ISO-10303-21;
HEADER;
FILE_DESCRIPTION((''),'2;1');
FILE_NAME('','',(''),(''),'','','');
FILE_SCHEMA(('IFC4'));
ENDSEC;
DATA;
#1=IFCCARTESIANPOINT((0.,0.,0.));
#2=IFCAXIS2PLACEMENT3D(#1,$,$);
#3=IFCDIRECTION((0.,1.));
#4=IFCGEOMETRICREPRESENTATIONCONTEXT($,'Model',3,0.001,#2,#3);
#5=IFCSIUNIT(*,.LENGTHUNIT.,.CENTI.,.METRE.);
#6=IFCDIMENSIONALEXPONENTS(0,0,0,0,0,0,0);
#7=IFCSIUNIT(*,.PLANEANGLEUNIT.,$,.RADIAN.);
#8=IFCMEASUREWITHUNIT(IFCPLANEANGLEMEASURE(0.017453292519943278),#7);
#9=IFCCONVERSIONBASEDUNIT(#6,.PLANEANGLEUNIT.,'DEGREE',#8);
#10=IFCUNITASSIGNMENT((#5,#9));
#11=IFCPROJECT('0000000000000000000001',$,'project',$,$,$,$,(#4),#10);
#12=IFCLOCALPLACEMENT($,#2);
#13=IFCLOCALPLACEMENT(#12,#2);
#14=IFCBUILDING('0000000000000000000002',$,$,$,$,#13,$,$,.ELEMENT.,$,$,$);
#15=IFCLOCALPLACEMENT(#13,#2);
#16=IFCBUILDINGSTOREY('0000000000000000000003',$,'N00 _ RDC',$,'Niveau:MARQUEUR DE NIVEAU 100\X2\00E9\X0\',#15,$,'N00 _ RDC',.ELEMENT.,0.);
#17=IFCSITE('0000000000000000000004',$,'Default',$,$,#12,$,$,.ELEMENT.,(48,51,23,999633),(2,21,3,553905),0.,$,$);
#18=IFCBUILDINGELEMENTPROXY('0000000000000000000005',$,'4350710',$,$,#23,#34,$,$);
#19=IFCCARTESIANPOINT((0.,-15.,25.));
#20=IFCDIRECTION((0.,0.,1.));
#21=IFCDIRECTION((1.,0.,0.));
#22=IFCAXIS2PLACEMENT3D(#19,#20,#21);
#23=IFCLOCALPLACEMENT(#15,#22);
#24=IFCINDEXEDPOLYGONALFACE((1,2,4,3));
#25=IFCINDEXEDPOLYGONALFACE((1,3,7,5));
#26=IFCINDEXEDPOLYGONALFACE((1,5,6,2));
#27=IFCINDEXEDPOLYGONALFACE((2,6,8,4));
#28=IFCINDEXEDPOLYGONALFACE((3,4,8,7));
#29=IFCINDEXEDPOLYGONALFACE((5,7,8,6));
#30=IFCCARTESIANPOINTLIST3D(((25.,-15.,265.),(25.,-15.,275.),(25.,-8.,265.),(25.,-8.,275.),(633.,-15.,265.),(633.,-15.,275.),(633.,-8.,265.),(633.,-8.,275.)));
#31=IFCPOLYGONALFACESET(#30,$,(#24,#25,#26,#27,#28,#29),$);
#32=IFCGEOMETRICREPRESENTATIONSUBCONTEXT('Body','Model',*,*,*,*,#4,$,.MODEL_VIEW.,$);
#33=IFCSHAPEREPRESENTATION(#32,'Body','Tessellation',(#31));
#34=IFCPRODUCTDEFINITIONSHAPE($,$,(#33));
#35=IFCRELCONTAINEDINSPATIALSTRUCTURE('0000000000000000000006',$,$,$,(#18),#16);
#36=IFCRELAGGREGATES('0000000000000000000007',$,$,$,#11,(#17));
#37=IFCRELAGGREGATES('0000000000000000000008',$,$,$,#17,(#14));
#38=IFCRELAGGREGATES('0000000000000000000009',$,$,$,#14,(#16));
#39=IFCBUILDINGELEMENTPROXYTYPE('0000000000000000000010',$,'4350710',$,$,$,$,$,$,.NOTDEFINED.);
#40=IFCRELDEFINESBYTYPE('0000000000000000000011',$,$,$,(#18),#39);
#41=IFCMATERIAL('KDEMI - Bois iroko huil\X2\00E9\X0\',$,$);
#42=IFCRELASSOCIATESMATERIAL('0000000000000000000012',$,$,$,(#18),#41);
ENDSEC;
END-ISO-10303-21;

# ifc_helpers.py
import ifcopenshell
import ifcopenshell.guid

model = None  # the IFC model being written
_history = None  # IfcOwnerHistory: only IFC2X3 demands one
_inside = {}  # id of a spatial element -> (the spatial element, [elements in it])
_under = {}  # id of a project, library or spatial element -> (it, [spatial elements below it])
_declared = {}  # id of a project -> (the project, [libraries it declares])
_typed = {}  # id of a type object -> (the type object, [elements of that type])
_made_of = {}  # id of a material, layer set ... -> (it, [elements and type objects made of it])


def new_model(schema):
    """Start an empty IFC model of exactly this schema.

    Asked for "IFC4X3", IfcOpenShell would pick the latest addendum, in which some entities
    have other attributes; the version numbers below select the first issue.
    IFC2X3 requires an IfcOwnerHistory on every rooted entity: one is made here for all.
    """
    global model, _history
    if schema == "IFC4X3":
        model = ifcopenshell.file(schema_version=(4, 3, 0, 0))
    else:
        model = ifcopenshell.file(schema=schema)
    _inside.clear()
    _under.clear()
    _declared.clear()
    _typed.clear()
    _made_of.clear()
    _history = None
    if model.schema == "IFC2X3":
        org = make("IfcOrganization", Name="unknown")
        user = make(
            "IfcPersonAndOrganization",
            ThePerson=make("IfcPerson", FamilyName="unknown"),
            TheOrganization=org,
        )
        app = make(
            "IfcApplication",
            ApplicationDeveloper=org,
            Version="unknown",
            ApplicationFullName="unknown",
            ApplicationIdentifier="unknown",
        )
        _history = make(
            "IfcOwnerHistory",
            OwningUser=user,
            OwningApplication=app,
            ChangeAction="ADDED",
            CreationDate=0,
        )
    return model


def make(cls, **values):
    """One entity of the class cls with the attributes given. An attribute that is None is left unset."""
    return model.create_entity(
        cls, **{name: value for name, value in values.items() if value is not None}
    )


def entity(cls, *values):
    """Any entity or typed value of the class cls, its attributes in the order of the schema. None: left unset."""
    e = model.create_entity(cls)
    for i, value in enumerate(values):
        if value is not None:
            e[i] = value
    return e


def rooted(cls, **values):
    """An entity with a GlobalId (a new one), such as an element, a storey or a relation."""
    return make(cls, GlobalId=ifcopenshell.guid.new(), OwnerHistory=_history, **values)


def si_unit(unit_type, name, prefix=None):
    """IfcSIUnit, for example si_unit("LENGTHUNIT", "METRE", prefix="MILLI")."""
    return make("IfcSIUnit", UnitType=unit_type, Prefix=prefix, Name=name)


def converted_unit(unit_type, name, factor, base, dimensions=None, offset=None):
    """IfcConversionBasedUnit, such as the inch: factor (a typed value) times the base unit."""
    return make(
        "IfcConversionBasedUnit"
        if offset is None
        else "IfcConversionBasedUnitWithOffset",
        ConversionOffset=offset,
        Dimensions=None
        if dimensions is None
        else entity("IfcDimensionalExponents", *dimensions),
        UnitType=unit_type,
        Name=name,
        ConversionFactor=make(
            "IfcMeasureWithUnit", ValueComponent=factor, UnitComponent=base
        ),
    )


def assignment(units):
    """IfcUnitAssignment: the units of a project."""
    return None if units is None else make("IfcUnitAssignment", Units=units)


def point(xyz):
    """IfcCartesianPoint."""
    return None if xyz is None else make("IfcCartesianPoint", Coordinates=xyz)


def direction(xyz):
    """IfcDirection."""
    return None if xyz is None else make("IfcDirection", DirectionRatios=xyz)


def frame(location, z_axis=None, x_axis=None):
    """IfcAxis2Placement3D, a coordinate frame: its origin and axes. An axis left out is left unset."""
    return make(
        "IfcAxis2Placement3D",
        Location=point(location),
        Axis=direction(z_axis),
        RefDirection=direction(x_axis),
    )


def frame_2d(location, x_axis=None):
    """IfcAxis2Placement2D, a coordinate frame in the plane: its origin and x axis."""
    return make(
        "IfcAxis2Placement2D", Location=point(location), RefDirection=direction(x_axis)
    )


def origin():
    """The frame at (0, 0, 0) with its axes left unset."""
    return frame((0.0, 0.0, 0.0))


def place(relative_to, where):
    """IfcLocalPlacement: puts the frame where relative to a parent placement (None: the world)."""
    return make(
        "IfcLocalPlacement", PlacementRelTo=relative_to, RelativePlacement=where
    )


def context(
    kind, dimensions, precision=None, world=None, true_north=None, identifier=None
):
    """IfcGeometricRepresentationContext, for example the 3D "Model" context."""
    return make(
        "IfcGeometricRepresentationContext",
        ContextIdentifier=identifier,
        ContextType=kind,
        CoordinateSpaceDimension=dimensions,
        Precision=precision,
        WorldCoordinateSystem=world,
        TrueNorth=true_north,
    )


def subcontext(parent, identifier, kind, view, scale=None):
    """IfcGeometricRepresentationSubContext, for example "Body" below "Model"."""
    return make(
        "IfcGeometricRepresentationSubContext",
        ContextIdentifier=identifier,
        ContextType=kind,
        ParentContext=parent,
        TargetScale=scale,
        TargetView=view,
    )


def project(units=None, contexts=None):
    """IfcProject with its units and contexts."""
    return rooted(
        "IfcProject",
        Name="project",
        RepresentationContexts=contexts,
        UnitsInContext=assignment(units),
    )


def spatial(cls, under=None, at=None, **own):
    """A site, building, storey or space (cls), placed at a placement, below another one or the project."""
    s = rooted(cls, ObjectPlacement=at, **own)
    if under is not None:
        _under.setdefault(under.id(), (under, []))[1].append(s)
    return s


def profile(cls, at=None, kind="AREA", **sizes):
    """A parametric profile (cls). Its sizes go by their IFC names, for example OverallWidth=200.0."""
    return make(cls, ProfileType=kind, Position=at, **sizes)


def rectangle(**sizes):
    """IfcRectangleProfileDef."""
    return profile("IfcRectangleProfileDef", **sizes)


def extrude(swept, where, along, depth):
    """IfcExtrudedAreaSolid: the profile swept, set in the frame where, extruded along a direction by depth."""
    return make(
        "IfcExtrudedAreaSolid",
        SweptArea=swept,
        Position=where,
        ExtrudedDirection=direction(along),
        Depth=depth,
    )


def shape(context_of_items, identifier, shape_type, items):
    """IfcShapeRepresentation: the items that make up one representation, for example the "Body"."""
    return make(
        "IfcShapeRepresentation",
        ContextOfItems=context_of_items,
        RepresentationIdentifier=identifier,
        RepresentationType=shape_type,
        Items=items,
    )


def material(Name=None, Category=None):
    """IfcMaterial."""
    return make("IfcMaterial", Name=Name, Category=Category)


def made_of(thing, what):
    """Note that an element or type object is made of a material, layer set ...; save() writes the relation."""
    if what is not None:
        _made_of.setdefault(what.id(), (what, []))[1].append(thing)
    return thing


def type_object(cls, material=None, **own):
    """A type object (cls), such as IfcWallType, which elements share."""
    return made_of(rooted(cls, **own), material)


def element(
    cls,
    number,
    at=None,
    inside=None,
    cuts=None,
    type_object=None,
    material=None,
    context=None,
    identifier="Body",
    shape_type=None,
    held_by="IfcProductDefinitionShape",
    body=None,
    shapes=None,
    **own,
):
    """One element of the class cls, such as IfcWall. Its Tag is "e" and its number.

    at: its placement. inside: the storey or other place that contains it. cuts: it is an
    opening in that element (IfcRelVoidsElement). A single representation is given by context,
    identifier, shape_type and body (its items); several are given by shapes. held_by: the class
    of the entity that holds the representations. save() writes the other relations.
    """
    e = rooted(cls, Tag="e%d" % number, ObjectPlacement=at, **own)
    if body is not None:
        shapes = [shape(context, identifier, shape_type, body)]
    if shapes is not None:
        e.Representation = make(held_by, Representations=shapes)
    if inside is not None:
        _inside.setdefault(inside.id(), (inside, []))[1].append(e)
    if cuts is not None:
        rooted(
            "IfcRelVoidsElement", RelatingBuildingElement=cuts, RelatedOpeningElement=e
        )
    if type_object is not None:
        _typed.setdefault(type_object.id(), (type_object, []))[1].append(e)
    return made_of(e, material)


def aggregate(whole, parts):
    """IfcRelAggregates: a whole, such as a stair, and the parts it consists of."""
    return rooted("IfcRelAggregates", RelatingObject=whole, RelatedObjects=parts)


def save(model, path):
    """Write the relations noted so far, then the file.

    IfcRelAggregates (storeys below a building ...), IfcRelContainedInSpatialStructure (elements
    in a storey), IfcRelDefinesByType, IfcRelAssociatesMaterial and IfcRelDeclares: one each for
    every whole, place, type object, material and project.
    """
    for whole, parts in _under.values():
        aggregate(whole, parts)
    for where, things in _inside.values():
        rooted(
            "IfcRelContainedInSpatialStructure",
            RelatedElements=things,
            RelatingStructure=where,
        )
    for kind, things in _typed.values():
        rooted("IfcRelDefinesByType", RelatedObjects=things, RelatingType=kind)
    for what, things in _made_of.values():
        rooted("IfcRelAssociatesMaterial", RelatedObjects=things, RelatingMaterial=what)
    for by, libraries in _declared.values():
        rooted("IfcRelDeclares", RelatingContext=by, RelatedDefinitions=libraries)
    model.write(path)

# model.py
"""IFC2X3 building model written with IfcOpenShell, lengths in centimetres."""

from ifc_helpers import new_model, entity, si_unit, converted_unit, direction, frame, frame_2d, origin, place, context, subcontext, project, spatial, rectangle, extrude, material, type_object, element, save


model = new_model("IFC2X3")

# Units and contexts
model_context = context("Model", 3, precision=0.001, world=origin(), true_north=direction((0.0, 1.0)))
body_context = subcontext(model_context, "Body", "Model", "MODEL_VIEW")
ifc_project = project(units=[si_unit("LENGTHUNIT", "METRE", prefix="CENTI"), converted_unit("PLANEANGLEUNIT", "DEGREE", entity("IfcPlaneAngleMeasure", 0.017453292519943278), si_unit("PLANEANGLEUNIT", "RADIAN"), dimensions=[0, 0, 0, 0, 0, 0, 0])], contexts=[model_context])

# Site, building, storey
site_placement = place(None, origin())
site = spatial("IfcSite", under=ifc_project, at=site_placement, Name="Default", CompositionType="ELEMENT", RefLatitude=(48, 51, 23, 999633), RefLongitude=(2, 21, 3, 553905), RefElevation=0.0)
building_placement = place(site_placement, origin())
building = spatial("IfcBuilding", under=site, at=building_placement, CompositionType="ELEMENT")
storey_placement = place(building_placement, origin())
storey = spatial("IfcBuildingStorey", under=building, at=storey_placement, Name="N00 _ RDC", ObjectType="Niveau:MARQUEUR DE NIVEAU 100é", LongName="N00 _ RDC", CompositionType="ELEMENT", Elevation=0.0)

# Shared definitions
ifc_material_1 = material(Name="KDEMI - Bois iroko huilé")

# Building element proxy
building_element_proxy_type_1 = type_object("IfcBuildingElementProxyType", Name="4350710", PredefinedType="NOTDEFINED")
proxy_1_placement = place(storey_placement, frame((0.0, -15.0, 25.0), z_axis=(0.0, 0.0, 1.0), x_axis=(1.0, 0.0, 0.0)))
element("IfcBuildingElementProxy", 1, at=proxy_1_placement, inside=storey, type_object=building_element_proxy_type_1, material=ifc_material_1, Name="4350710", context=body_context, shape_type="SweptSolid", body=[
    extrude(rectangle(XDim=608.0, YDim=7.0, at=frame_2d((0.0, 0.0), x_axis=(1.0, 0.0))), frame((329.0, -11.5, 265.0)), (0.0, 0.0, 1.0), 10.0),
])

save(model, "model.ifc")
